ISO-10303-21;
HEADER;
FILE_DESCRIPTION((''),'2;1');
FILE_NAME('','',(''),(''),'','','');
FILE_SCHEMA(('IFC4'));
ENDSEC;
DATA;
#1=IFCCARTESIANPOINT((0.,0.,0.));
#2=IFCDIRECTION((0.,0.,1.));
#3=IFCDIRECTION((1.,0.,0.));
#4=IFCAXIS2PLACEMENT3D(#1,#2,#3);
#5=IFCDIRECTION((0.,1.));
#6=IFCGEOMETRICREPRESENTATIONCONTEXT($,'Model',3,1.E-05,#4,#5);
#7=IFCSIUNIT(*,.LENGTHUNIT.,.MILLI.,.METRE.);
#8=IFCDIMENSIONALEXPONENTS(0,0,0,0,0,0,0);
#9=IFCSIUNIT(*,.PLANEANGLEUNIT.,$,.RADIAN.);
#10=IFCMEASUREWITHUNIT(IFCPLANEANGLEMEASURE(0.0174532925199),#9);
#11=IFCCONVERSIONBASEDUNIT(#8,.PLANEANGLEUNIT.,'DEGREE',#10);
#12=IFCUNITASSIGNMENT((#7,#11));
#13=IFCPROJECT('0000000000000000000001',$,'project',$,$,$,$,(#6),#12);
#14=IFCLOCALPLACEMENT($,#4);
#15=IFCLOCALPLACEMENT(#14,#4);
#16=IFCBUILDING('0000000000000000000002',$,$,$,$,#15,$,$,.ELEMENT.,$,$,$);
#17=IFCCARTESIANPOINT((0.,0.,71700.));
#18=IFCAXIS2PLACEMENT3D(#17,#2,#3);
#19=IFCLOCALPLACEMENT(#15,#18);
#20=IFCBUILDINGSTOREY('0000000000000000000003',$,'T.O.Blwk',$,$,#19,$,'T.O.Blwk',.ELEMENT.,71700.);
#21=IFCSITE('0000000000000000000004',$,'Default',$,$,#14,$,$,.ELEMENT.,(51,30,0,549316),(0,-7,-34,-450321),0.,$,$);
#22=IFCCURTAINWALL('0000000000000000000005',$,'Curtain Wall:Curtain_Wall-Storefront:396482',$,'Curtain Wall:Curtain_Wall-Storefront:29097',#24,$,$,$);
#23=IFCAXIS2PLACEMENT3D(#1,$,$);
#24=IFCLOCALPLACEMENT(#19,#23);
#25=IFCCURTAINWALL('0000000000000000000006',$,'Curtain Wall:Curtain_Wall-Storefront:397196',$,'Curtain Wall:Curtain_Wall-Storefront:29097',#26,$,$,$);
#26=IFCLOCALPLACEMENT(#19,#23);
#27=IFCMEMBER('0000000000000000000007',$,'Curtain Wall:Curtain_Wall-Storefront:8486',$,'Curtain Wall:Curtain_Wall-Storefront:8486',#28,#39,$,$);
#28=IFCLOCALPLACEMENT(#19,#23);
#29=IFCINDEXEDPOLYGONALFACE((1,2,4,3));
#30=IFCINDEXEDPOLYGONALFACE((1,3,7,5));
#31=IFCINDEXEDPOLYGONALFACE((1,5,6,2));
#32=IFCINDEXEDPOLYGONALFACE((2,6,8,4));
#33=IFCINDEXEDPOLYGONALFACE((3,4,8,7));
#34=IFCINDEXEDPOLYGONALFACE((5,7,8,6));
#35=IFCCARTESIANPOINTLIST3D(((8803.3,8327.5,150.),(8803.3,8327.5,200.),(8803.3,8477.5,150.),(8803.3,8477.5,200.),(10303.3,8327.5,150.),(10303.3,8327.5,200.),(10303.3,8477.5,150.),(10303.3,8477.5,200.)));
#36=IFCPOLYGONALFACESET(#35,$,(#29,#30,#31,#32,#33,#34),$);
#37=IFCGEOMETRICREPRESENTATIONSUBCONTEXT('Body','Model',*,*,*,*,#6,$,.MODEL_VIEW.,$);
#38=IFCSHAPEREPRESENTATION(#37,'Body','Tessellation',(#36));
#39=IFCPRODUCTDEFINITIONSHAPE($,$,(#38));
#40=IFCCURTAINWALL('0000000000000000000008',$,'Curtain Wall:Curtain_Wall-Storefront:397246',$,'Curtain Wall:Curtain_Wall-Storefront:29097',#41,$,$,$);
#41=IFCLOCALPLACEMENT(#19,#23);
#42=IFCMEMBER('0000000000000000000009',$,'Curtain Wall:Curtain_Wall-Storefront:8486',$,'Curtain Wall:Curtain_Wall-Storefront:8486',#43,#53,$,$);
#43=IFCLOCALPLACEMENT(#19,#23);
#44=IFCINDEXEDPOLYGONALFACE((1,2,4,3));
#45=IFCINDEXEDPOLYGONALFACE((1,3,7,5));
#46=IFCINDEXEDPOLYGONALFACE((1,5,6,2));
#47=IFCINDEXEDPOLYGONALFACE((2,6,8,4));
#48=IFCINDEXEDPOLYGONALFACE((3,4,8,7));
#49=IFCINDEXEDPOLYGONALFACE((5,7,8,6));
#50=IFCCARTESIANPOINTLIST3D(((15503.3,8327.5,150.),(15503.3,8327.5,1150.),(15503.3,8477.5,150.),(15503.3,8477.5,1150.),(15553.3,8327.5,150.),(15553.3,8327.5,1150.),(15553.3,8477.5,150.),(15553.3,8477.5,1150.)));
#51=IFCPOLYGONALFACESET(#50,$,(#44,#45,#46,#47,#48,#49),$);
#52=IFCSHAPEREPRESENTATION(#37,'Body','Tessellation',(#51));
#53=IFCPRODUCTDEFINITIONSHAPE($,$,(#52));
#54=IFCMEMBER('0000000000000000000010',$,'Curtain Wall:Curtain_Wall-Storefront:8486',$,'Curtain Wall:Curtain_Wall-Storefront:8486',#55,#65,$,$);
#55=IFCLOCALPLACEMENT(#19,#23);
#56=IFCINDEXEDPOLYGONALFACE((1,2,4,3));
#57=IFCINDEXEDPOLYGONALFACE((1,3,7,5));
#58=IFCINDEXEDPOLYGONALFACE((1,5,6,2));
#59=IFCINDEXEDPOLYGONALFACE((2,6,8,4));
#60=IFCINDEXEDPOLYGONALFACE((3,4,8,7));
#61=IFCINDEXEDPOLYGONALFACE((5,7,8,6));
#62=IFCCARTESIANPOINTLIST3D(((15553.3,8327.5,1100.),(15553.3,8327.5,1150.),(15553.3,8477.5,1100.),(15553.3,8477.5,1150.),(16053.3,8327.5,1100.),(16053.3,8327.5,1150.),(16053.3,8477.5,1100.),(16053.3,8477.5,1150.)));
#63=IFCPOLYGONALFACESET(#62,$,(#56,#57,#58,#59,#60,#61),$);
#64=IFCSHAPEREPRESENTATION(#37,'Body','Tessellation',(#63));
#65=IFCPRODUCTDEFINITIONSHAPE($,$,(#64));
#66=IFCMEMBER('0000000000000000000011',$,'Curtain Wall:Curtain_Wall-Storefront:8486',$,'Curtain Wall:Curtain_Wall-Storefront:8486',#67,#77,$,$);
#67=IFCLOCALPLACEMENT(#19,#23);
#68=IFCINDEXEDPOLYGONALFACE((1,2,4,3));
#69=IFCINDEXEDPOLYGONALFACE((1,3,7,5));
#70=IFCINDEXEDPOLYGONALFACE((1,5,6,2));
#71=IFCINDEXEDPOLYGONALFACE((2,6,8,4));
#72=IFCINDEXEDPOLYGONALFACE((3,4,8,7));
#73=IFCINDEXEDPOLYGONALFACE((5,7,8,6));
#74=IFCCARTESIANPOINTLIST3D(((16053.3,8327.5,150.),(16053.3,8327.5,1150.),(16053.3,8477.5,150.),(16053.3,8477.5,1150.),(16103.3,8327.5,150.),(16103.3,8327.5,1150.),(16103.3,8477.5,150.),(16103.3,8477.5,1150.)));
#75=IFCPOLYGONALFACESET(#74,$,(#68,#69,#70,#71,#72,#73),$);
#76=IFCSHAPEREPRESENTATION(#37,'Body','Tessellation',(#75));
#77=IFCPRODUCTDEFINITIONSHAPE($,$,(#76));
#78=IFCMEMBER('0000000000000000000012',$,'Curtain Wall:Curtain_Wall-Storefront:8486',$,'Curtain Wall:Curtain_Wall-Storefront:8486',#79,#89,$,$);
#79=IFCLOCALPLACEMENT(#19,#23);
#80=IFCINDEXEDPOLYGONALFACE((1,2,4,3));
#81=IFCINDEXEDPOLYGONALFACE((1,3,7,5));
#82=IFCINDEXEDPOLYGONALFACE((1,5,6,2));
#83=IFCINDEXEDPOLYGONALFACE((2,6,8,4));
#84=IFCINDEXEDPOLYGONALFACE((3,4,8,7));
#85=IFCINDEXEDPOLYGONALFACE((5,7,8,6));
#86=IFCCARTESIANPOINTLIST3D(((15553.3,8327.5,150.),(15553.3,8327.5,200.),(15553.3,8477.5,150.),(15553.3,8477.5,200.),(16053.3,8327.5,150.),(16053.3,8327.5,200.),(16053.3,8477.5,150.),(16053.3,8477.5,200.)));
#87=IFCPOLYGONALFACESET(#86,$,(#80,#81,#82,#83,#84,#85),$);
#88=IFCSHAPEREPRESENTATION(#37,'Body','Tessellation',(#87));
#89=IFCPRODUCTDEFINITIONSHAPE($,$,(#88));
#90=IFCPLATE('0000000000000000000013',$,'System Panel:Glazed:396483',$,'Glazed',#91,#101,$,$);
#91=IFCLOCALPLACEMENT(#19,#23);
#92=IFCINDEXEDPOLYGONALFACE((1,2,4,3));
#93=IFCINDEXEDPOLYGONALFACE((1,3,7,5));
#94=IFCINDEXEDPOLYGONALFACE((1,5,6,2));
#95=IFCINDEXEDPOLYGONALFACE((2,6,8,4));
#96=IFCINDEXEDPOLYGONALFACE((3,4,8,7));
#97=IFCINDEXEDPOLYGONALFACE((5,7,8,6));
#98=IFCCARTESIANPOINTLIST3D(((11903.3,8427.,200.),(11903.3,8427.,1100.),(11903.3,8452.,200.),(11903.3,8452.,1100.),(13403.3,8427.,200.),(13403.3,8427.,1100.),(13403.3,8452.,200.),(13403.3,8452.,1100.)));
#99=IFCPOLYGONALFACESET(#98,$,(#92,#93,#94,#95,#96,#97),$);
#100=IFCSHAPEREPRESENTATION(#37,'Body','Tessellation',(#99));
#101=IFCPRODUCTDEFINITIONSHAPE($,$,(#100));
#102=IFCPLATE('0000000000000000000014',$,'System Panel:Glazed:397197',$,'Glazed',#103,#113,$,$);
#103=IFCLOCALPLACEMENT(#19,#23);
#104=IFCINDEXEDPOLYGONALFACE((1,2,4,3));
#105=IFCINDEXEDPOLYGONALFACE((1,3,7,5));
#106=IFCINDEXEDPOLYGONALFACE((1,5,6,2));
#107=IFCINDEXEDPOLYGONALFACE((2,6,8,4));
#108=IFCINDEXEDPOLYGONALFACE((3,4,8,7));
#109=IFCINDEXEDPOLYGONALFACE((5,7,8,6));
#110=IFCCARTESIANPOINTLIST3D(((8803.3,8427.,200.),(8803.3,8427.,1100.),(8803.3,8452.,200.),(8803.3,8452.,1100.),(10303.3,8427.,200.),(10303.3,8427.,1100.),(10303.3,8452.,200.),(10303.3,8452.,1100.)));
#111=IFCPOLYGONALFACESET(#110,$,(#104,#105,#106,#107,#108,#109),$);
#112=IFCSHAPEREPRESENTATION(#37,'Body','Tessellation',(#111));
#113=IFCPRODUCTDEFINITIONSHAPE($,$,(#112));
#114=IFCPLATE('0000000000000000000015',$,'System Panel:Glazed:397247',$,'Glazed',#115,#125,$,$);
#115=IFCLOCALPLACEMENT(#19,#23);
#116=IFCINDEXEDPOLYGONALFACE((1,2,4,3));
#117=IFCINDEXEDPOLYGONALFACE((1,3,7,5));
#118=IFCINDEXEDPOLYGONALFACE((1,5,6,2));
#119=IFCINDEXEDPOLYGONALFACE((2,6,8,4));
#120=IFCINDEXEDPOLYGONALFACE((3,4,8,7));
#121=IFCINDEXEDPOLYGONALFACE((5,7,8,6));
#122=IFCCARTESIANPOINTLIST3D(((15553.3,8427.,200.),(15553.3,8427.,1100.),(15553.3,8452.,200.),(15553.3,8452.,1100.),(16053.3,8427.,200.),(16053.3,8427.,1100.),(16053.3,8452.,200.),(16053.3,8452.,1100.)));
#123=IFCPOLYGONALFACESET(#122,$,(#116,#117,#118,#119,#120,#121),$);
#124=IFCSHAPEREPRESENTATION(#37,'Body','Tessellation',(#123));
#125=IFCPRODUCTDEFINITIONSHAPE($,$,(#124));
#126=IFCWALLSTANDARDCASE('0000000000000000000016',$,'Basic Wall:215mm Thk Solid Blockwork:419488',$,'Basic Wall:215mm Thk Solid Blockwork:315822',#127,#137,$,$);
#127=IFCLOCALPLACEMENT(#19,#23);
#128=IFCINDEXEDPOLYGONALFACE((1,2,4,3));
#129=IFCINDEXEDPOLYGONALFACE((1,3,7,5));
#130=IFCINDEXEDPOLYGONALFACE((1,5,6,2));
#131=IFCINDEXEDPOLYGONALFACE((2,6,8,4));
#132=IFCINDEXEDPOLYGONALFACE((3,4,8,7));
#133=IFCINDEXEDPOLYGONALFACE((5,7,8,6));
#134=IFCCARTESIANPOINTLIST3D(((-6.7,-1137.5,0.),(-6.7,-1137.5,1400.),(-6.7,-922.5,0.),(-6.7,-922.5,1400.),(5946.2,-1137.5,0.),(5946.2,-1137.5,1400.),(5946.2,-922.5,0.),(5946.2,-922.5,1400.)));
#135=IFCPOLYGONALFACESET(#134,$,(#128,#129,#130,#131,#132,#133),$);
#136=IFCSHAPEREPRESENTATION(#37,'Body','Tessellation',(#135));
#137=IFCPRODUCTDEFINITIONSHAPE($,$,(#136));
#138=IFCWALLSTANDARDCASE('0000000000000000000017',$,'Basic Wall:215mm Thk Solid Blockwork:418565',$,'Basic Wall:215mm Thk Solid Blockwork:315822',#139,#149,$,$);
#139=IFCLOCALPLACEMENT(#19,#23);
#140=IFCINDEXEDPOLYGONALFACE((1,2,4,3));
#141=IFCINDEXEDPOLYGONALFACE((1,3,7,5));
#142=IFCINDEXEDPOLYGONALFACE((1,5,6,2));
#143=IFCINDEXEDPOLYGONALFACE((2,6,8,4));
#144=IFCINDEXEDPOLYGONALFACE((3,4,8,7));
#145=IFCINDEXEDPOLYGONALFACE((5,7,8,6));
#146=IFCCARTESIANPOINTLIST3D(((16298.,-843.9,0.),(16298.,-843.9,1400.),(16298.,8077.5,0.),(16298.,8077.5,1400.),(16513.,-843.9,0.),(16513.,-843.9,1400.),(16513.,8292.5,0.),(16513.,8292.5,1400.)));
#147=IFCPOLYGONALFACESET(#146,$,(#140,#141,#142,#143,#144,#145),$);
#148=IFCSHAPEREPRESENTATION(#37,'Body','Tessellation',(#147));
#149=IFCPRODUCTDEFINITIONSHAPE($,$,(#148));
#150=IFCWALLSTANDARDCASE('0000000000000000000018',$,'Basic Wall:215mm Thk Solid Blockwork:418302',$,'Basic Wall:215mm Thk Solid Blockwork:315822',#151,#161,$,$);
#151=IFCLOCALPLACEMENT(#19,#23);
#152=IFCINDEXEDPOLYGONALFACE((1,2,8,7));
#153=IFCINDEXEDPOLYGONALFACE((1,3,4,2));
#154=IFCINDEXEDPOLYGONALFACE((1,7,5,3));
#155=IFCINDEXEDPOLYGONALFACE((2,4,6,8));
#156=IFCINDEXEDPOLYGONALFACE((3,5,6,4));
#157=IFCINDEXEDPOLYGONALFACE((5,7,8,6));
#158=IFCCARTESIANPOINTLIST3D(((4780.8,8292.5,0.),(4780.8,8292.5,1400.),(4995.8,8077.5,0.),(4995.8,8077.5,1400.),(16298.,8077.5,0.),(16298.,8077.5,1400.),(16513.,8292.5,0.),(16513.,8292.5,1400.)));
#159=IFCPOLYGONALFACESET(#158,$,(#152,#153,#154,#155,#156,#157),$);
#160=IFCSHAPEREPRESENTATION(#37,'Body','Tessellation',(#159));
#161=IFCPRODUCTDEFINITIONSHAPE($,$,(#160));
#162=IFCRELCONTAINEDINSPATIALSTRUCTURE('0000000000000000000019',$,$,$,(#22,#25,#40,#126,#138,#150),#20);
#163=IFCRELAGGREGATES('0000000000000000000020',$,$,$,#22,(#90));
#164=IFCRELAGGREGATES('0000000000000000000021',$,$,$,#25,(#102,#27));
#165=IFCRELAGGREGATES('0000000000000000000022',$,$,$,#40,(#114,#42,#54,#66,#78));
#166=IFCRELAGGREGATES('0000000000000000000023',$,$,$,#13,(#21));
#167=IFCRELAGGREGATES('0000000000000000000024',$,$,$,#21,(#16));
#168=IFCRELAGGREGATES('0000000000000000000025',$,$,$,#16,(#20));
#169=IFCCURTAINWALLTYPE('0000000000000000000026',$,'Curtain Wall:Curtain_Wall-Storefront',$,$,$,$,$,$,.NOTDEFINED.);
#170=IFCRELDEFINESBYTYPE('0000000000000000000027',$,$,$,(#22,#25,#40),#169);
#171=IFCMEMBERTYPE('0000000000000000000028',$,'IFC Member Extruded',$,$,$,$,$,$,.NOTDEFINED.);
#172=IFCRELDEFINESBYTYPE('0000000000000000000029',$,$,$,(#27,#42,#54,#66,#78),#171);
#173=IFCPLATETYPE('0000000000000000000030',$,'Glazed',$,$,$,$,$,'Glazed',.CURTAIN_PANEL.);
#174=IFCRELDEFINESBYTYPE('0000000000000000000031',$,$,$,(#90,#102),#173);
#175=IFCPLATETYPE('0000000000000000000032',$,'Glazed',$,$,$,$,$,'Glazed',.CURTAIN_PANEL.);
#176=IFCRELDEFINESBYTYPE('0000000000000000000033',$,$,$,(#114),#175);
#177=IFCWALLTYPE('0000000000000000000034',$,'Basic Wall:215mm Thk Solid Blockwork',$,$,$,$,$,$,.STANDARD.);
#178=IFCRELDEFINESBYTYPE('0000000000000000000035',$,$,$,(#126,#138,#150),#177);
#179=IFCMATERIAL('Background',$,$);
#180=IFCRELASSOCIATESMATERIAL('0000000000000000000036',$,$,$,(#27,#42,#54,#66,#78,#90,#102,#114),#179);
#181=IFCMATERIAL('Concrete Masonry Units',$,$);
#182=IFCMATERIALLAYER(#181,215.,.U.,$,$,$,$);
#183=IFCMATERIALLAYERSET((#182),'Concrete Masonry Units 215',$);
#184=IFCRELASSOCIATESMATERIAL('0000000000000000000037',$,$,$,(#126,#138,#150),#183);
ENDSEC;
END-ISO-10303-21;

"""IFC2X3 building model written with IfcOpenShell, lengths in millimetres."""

from ifc_helpers import new_model, entity, si_unit, converted_unit, direction, frame, origin_with_axes, origin_2d_with_axis, place, context, subcontext, project, spatial, polyline, rectangle, outline, extrude, material, layer, layer_set, layer_usage, type_object, element, aggregate, save


model = new_model("IFC2X3")

# Units and contexts
model_context = context("Model", 3, precision=1e-05, world=origin_with_axes(), true_north=direction((0.0, 1.0)))
body_context = subcontext(model_context, "Body", "Model", "MODEL_VIEW")
ifc_project = project(units=[si_unit("LENGTHUNIT", "METRE", prefix="MILLI"), converted_unit("PLANEANGLEUNIT", "DEGREE", entity("IfcPlaneAngleMeasure", 0.0174532925199), si_unit("PLANEANGLEUNIT", "RADIAN"), dimensions=[0, 0, 0, 0, 0, 0, 0])], contexts=[model_context])

# Site, building, storey
site_placement = place(None, origin_with_axes())
site = spatial("IfcSite", under=ifc_project, at=site_placement, Name="Default", CompositionType="ELEMENT", RefLatitude=(51, 30, 0, 549316), RefLongitude=(0, -7, -34, -450321), RefElevation=0.0)
building_placement = place(site_placement, origin_with_axes())
building = spatial("IfcBuilding", under=site, at=building_placement, CompositionType="ELEMENT")
storey_placement = place(building_placement, frame((0.0, 0.0, 71700.0), z_axis=(0.0, 0.0, 1.0), x_axis=(1.0, 0.0, 0.0)))
storey = spatial("IfcBuildingStorey", under=building, at=storey_placement, Name="T.O.Blwk", LongName="T.O.Blwk", CompositionType="ELEMENT", Elevation=71700.0)

# Curtain walls, members
curtain_wall_type = type_object("IfcCurtainWallType", Name="Curtain Wall:Curtain_Wall-Storefront", PredefinedType="NOTDEFINED")
curtain_wall_1_placement = place(storey_placement, frame((0.0, 0.0, -71700.0), z_axis=(0.0, 0.0, 1.0), x_axis=(1.0, 0.0, 0.0)))
curtain_wall_1 = element("IfcCurtainWall", 1, at=curtain_wall_1_placement, inside=storey, type_object=curtain_wall_type, Name="Curtain Wall:Curtain_Wall-Storefront:396482", ObjectType="Curtain Wall:Curtain_Wall-Storefront:29097")
ifc_material_1 = material(Name="Background")
member_type = type_object("IfcMemberType", Name="IFC Member Extruded", PredefinedType="NOTDEFINED")
curtain_wall_2_placement = place(storey_placement, frame((0.0, 0.0, -71700.0), z_axis=(0.0, 0.0, 1.0), x_axis=(1.0, 0.0, 0.0)))
curtain_wall_2 = element("IfcCurtainWall", 2, at=curtain_wall_2_placement, inside=storey, type_object=curtain_wall_type, Name="Curtain Wall:Curtain_Wall-Storefront:397196", ObjectType="Curtain Wall:Curtain_Wall-Storefront:29097")
member_1_placement = place(curtain_wall_2_placement, frame((0.0, 0.0, 71700.0), z_axis=(0.0, 0.0, 1.0), x_axis=(1.0, 0.0, 0.0)))
member_1 = element("IfcMember", 3, at=member_1_placement, type_object=member_type, material=ifc_material_1, Name="Curtain Wall:Curtain_Wall-Storefront:8486", ObjectType="Curtain Wall:Curtain_Wall-Storefront:8486", context=body_context, shape_type="SweptSolid", body=[
    extrude(rectangle(XDim=50.0, YDim=150.0, at=origin_2d_with_axis()), frame((8803.3, 8402.5, 175.0), z_axis=(1.0, 0.0, 0.0), x_axis=(0.0, 0.0, -1.0)), (0.0, 0.0, 1.0), 1500.0),
])
curtain_wall_3_placement = place(storey_placement, frame((0.0, 0.0, -71700.0), z_axis=(0.0, 0.0, 1.0), x_axis=(1.0, 0.0, 0.0)))
curtain_wall_3 = element("IfcCurtainWall", 4, at=curtain_wall_3_placement, inside=storey, type_object=curtain_wall_type, Name="Curtain Wall:Curtain_Wall-Storefront:397246", ObjectType="Curtain Wall:Curtain_Wall-Storefront:29097")
member_2_placement = place(curtain_wall_3_placement, frame((0.0, 0.0, 71700.0), z_axis=(0.0, 0.0, 1.0), x_axis=(1.0, 0.0, 0.0)))
member_2 = element("IfcMember", 5, at=member_2_placement, type_object=member_type, material=ifc_material_1, Name="Curtain Wall:Curtain_Wall-Storefront:8486", ObjectType="Curtain Wall:Curtain_Wall-Storefront:8486", context=body_context, shape_type="SweptSolid", body=[
    extrude(rectangle(XDim=50.0, YDim=150.0, at=origin_2d_with_axis()), frame((15528.3, 8402.5, 1150.0), z_axis=(0.0, 0.0, -1.0), x_axis=(-1.0, 0.0, 0.0)), (0.0, 0.0, 1.0), 1000.0),
])
member_3_placement = place(curtain_wall_3_placement, frame((0.0, 0.0, 71700.0), z_axis=(0.0, 0.0, 1.0), x_axis=(1.0, 0.0, 0.0)))
member_3 = element("IfcMember", 6, at=member_3_placement, type_object=member_type, material=ifc_material_1, Name="Curtain Wall:Curtain_Wall-Storefront:8486", ObjectType="Curtain Wall:Curtain_Wall-Storefront:8486", context=body_context, shape_type="SweptSolid", body=[
    extrude(rectangle(XDim=50.0, YDim=150.0, at=origin_2d_with_axis()), frame((16053.3, 8402.5, 1125.0), z_axis=(-1.0, 0.0, 0.0), x_axis=(0.0, 0.0, -1.0)), (0.0, 0.0, 1.0), 500.0),
])
member_4_placement = place(curtain_wall_3_placement, frame((0.0, 0.0, 71700.0), z_axis=(0.0, 0.0, 1.0), x_axis=(1.0, 0.0, 0.0)))
member_4 = element("IfcMember", 7, at=member_4_placement, type_object=member_type, material=ifc_material_1, Name="Curtain Wall:Curtain_Wall-Storefront:8486", ObjectType="Curtain Wall:Curtain_Wall-Storefront:8486", context=body_context, shape_type="SweptSolid", body=[
    extrude(rectangle(XDim=50.0, YDim=150.0, at=origin_2d_with_axis()), frame((16078.3, 8402.5, 150.0), z_axis=(0.0, 0.0, 1.0), x_axis=(-1.0, 0.0, 0.0)), (0.0, 0.0, 1.0), 1000.0),
])
member_5_placement = place(curtain_wall_3_placement, frame((0.0, 0.0, 71700.0), z_axis=(0.0, 0.0, 1.0), x_axis=(1.0, 0.0, 0.0)))
member_5 = element("IfcMember", 8, at=member_5_placement, type_object=member_type, material=ifc_material_1, Name="Curtain Wall:Curtain_Wall-Storefront:8486", ObjectType="Curtain Wall:Curtain_Wall-Storefront:8486", context=body_context, shape_type="SweptSolid", body=[
    extrude(rectangle(XDim=50.0, YDim=150.0, at=origin_2d_with_axis()), frame((15553.3, 8402.5, 175.0), z_axis=(1.0, 0.0, 0.0), x_axis=(0.0, 0.0, -1.0)), (0.0, 0.0, 1.0), 500.0),
])

# Plates
plate_type_1 = type_object("IfcPlateType", Name="Glazed", ElementType="Glazed", PredefinedType="CURTAIN_PANEL")
plate_1_placement = place(curtain_wall_1_placement, frame((11903.3, 8427.0, 71900.0), z_axis=(0.0, 0.0, 1.0), x_axis=(1.0, 0.0, 0.0)))
plate_1 = element("IfcPlate", 9, at=plate_1_placement, type_object=plate_type_1, material=ifc_material_1, Name="System Panel:Glazed:396483", ObjectType="Glazed", context=body_context, shape_type="SweptSolid", body=[
    extrude(rectangle(XDim=25.0, YDim=1500.0, at=origin_2d_with_axis()), frame((750.0, 12.5, 0.0), z_axis=(0.0, 0.0, 1.0), x_axis=(0.0, 1.0, 0.0)), (0.0, 0.0, 1.0), 900.0),
])
aggregate(curtain_wall_1, [plate_1])
plate_2_placement = place(curtain_wall_2_placement, frame((8803.3, 8427.0, 71900.0), z_axis=(0.0, 0.0, 1.0), x_axis=(1.0, 0.0, 0.0)))
plate_2 = element("IfcPlate", 10, at=plate_2_placement, type_object=plate_type_1, material=ifc_material_1, Name="System Panel:Glazed:397197", ObjectType="Glazed", context=body_context, shape_type="SweptSolid", body=[
    extrude(rectangle(XDim=25.0, YDim=1500.0, at=origin_2d_with_axis()), frame((750.0, 12.5, 0.0), z_axis=(0.0, 0.0, 1.0), x_axis=(0.0, 1.0, 0.0)), (0.0, 0.0, 1.0), 900.0),
])
aggregate(curtain_wall_2, [plate_2, member_1])
plate_type_2 = type_object("IfcPlateType", Name="Glazed", ElementType="Glazed", PredefinedType="CURTAIN_PANEL")
plate_3_placement = place(curtain_wall_3_placement, frame((15553.3, 8427.0, 71900.0), z_axis=(0.0, 0.0, 1.0), x_axis=(1.0, 0.0, 0.0)))
plate_3 = element("IfcPlate", 11, at=plate_3_placement, type_object=plate_type_2, material=ifc_material_1, Name="System Panel:Glazed:397247", ObjectType="Glazed", context=body_context, shape_type="SweptSolid", body=[
    extrude(rectangle(XDim=25.0, YDim=500.0, at=origin_2d_with_axis()), frame((250.0, 12.5, 0.0), z_axis=(0.0, 0.0, 1.0), x_axis=(0.0, 1.0, 0.0)), (0.0, 0.0, 1.0), 900.0),
])
aggregate(curtain_wall_3, [plate_3, member_2, member_3, member_4, member_5])

# Walls
ifc_material_2 = material(Name="Concrete Masonry Units")
ifc_layer_1 = layer(ifc_material_2, 215.0, ventilated="UNKNOWN")
ifc_layer_set_1 = layer_set([ifc_layer_1], Name="Concrete Masonry Units 215")
ifc_layer_usage_1 = layer_usage(ifc_layer_set_1, "AXIS2", "POSITIVE", -107.5)
wall_type_1 = type_object("IfcWallType", Name="Basic Wall:215mm Thk Solid Blockwork", PredefinedType="STANDARD")
wall_1_placement = place(storey_placement, frame((-6.7, -1030.0, 0.0), z_axis=(0.0, 0.0, 1.0), x_axis=(1.0, 0.0, 0.0)))
element("IfcWallStandardCase", 12, at=wall_1_placement, inside=storey, type_object=wall_type_1, material=ifc_layer_usage_1, Name="Basic Wall:215mm Thk Solid Blockwork:419488", ObjectType="Basic Wall:215mm Thk Solid Blockwork:315822", context=body_context, shape_type="SweptSolid", body=[
    extrude(outline(polyline([(0.0, -107.5), (5952.9, -107.5), (5952.9, 107.5), (0.0, 107.5), (0.0, -107.5)])), origin_with_axes(), (0.0, 0.0, 1.0), 1400.0),
])
ifc_layer_usage_2 = layer_usage(ifc_layer_set_1, "AXIS2", "POSITIVE", -107.5)
wall_2_placement = place(storey_placement, frame((16405.5, 8185.0, 0.0), z_axis=(0.0, 0.0, 1.0), x_axis=(0.0, -1.0, 0.0)))
element("IfcWallStandardCase", 13, at=wall_2_placement, inside=storey, type_object=wall_type_1, material=ifc_layer_usage_2, Name="Basic Wall:215mm Thk Solid Blockwork:418565", ObjectType="Basic Wall:215mm Thk Solid Blockwork:315822", context=body_context, shape_type="SweptSolid", body=[
    extrude(outline(polyline([(107.5, -107.5), (9028.9, -107.5), (9028.9, 107.5), (-107.5, 107.5), (107.5, -107.5)])), origin_with_axes(), (0.0, 0.0, 1.0), 1400.0),
])
ifc_layer_usage_3 = layer_usage(ifc_layer_set_1, "AXIS2", "POSITIVE", -107.5)
wall_3_placement = place(storey_placement, frame((4888.3, 8185.0, 0.0), z_axis=(0.0, 0.0, 1.0), x_axis=(1.0, 0.0, 0.0)))
element("IfcWallStandardCase", 14, at=wall_3_placement, inside=storey, type_object=wall_type_1, material=ifc_layer_usage_3, Name="Basic Wall:215mm Thk Solid Blockwork:418302", ObjectType="Basic Wall:215mm Thk Solid Blockwork:315822", context=body_context, shape_type="SweptSolid", body=[
    extrude(outline(polyline([(107.5, -107.5), (11409.8, -107.5), (11624.8, 107.5), (-107.5, 107.5), (107.5, -107.5)])), origin_with_axes(), (0.0, 0.0, 1.0), 1400.0),
])

save(model, "model.ifc")
